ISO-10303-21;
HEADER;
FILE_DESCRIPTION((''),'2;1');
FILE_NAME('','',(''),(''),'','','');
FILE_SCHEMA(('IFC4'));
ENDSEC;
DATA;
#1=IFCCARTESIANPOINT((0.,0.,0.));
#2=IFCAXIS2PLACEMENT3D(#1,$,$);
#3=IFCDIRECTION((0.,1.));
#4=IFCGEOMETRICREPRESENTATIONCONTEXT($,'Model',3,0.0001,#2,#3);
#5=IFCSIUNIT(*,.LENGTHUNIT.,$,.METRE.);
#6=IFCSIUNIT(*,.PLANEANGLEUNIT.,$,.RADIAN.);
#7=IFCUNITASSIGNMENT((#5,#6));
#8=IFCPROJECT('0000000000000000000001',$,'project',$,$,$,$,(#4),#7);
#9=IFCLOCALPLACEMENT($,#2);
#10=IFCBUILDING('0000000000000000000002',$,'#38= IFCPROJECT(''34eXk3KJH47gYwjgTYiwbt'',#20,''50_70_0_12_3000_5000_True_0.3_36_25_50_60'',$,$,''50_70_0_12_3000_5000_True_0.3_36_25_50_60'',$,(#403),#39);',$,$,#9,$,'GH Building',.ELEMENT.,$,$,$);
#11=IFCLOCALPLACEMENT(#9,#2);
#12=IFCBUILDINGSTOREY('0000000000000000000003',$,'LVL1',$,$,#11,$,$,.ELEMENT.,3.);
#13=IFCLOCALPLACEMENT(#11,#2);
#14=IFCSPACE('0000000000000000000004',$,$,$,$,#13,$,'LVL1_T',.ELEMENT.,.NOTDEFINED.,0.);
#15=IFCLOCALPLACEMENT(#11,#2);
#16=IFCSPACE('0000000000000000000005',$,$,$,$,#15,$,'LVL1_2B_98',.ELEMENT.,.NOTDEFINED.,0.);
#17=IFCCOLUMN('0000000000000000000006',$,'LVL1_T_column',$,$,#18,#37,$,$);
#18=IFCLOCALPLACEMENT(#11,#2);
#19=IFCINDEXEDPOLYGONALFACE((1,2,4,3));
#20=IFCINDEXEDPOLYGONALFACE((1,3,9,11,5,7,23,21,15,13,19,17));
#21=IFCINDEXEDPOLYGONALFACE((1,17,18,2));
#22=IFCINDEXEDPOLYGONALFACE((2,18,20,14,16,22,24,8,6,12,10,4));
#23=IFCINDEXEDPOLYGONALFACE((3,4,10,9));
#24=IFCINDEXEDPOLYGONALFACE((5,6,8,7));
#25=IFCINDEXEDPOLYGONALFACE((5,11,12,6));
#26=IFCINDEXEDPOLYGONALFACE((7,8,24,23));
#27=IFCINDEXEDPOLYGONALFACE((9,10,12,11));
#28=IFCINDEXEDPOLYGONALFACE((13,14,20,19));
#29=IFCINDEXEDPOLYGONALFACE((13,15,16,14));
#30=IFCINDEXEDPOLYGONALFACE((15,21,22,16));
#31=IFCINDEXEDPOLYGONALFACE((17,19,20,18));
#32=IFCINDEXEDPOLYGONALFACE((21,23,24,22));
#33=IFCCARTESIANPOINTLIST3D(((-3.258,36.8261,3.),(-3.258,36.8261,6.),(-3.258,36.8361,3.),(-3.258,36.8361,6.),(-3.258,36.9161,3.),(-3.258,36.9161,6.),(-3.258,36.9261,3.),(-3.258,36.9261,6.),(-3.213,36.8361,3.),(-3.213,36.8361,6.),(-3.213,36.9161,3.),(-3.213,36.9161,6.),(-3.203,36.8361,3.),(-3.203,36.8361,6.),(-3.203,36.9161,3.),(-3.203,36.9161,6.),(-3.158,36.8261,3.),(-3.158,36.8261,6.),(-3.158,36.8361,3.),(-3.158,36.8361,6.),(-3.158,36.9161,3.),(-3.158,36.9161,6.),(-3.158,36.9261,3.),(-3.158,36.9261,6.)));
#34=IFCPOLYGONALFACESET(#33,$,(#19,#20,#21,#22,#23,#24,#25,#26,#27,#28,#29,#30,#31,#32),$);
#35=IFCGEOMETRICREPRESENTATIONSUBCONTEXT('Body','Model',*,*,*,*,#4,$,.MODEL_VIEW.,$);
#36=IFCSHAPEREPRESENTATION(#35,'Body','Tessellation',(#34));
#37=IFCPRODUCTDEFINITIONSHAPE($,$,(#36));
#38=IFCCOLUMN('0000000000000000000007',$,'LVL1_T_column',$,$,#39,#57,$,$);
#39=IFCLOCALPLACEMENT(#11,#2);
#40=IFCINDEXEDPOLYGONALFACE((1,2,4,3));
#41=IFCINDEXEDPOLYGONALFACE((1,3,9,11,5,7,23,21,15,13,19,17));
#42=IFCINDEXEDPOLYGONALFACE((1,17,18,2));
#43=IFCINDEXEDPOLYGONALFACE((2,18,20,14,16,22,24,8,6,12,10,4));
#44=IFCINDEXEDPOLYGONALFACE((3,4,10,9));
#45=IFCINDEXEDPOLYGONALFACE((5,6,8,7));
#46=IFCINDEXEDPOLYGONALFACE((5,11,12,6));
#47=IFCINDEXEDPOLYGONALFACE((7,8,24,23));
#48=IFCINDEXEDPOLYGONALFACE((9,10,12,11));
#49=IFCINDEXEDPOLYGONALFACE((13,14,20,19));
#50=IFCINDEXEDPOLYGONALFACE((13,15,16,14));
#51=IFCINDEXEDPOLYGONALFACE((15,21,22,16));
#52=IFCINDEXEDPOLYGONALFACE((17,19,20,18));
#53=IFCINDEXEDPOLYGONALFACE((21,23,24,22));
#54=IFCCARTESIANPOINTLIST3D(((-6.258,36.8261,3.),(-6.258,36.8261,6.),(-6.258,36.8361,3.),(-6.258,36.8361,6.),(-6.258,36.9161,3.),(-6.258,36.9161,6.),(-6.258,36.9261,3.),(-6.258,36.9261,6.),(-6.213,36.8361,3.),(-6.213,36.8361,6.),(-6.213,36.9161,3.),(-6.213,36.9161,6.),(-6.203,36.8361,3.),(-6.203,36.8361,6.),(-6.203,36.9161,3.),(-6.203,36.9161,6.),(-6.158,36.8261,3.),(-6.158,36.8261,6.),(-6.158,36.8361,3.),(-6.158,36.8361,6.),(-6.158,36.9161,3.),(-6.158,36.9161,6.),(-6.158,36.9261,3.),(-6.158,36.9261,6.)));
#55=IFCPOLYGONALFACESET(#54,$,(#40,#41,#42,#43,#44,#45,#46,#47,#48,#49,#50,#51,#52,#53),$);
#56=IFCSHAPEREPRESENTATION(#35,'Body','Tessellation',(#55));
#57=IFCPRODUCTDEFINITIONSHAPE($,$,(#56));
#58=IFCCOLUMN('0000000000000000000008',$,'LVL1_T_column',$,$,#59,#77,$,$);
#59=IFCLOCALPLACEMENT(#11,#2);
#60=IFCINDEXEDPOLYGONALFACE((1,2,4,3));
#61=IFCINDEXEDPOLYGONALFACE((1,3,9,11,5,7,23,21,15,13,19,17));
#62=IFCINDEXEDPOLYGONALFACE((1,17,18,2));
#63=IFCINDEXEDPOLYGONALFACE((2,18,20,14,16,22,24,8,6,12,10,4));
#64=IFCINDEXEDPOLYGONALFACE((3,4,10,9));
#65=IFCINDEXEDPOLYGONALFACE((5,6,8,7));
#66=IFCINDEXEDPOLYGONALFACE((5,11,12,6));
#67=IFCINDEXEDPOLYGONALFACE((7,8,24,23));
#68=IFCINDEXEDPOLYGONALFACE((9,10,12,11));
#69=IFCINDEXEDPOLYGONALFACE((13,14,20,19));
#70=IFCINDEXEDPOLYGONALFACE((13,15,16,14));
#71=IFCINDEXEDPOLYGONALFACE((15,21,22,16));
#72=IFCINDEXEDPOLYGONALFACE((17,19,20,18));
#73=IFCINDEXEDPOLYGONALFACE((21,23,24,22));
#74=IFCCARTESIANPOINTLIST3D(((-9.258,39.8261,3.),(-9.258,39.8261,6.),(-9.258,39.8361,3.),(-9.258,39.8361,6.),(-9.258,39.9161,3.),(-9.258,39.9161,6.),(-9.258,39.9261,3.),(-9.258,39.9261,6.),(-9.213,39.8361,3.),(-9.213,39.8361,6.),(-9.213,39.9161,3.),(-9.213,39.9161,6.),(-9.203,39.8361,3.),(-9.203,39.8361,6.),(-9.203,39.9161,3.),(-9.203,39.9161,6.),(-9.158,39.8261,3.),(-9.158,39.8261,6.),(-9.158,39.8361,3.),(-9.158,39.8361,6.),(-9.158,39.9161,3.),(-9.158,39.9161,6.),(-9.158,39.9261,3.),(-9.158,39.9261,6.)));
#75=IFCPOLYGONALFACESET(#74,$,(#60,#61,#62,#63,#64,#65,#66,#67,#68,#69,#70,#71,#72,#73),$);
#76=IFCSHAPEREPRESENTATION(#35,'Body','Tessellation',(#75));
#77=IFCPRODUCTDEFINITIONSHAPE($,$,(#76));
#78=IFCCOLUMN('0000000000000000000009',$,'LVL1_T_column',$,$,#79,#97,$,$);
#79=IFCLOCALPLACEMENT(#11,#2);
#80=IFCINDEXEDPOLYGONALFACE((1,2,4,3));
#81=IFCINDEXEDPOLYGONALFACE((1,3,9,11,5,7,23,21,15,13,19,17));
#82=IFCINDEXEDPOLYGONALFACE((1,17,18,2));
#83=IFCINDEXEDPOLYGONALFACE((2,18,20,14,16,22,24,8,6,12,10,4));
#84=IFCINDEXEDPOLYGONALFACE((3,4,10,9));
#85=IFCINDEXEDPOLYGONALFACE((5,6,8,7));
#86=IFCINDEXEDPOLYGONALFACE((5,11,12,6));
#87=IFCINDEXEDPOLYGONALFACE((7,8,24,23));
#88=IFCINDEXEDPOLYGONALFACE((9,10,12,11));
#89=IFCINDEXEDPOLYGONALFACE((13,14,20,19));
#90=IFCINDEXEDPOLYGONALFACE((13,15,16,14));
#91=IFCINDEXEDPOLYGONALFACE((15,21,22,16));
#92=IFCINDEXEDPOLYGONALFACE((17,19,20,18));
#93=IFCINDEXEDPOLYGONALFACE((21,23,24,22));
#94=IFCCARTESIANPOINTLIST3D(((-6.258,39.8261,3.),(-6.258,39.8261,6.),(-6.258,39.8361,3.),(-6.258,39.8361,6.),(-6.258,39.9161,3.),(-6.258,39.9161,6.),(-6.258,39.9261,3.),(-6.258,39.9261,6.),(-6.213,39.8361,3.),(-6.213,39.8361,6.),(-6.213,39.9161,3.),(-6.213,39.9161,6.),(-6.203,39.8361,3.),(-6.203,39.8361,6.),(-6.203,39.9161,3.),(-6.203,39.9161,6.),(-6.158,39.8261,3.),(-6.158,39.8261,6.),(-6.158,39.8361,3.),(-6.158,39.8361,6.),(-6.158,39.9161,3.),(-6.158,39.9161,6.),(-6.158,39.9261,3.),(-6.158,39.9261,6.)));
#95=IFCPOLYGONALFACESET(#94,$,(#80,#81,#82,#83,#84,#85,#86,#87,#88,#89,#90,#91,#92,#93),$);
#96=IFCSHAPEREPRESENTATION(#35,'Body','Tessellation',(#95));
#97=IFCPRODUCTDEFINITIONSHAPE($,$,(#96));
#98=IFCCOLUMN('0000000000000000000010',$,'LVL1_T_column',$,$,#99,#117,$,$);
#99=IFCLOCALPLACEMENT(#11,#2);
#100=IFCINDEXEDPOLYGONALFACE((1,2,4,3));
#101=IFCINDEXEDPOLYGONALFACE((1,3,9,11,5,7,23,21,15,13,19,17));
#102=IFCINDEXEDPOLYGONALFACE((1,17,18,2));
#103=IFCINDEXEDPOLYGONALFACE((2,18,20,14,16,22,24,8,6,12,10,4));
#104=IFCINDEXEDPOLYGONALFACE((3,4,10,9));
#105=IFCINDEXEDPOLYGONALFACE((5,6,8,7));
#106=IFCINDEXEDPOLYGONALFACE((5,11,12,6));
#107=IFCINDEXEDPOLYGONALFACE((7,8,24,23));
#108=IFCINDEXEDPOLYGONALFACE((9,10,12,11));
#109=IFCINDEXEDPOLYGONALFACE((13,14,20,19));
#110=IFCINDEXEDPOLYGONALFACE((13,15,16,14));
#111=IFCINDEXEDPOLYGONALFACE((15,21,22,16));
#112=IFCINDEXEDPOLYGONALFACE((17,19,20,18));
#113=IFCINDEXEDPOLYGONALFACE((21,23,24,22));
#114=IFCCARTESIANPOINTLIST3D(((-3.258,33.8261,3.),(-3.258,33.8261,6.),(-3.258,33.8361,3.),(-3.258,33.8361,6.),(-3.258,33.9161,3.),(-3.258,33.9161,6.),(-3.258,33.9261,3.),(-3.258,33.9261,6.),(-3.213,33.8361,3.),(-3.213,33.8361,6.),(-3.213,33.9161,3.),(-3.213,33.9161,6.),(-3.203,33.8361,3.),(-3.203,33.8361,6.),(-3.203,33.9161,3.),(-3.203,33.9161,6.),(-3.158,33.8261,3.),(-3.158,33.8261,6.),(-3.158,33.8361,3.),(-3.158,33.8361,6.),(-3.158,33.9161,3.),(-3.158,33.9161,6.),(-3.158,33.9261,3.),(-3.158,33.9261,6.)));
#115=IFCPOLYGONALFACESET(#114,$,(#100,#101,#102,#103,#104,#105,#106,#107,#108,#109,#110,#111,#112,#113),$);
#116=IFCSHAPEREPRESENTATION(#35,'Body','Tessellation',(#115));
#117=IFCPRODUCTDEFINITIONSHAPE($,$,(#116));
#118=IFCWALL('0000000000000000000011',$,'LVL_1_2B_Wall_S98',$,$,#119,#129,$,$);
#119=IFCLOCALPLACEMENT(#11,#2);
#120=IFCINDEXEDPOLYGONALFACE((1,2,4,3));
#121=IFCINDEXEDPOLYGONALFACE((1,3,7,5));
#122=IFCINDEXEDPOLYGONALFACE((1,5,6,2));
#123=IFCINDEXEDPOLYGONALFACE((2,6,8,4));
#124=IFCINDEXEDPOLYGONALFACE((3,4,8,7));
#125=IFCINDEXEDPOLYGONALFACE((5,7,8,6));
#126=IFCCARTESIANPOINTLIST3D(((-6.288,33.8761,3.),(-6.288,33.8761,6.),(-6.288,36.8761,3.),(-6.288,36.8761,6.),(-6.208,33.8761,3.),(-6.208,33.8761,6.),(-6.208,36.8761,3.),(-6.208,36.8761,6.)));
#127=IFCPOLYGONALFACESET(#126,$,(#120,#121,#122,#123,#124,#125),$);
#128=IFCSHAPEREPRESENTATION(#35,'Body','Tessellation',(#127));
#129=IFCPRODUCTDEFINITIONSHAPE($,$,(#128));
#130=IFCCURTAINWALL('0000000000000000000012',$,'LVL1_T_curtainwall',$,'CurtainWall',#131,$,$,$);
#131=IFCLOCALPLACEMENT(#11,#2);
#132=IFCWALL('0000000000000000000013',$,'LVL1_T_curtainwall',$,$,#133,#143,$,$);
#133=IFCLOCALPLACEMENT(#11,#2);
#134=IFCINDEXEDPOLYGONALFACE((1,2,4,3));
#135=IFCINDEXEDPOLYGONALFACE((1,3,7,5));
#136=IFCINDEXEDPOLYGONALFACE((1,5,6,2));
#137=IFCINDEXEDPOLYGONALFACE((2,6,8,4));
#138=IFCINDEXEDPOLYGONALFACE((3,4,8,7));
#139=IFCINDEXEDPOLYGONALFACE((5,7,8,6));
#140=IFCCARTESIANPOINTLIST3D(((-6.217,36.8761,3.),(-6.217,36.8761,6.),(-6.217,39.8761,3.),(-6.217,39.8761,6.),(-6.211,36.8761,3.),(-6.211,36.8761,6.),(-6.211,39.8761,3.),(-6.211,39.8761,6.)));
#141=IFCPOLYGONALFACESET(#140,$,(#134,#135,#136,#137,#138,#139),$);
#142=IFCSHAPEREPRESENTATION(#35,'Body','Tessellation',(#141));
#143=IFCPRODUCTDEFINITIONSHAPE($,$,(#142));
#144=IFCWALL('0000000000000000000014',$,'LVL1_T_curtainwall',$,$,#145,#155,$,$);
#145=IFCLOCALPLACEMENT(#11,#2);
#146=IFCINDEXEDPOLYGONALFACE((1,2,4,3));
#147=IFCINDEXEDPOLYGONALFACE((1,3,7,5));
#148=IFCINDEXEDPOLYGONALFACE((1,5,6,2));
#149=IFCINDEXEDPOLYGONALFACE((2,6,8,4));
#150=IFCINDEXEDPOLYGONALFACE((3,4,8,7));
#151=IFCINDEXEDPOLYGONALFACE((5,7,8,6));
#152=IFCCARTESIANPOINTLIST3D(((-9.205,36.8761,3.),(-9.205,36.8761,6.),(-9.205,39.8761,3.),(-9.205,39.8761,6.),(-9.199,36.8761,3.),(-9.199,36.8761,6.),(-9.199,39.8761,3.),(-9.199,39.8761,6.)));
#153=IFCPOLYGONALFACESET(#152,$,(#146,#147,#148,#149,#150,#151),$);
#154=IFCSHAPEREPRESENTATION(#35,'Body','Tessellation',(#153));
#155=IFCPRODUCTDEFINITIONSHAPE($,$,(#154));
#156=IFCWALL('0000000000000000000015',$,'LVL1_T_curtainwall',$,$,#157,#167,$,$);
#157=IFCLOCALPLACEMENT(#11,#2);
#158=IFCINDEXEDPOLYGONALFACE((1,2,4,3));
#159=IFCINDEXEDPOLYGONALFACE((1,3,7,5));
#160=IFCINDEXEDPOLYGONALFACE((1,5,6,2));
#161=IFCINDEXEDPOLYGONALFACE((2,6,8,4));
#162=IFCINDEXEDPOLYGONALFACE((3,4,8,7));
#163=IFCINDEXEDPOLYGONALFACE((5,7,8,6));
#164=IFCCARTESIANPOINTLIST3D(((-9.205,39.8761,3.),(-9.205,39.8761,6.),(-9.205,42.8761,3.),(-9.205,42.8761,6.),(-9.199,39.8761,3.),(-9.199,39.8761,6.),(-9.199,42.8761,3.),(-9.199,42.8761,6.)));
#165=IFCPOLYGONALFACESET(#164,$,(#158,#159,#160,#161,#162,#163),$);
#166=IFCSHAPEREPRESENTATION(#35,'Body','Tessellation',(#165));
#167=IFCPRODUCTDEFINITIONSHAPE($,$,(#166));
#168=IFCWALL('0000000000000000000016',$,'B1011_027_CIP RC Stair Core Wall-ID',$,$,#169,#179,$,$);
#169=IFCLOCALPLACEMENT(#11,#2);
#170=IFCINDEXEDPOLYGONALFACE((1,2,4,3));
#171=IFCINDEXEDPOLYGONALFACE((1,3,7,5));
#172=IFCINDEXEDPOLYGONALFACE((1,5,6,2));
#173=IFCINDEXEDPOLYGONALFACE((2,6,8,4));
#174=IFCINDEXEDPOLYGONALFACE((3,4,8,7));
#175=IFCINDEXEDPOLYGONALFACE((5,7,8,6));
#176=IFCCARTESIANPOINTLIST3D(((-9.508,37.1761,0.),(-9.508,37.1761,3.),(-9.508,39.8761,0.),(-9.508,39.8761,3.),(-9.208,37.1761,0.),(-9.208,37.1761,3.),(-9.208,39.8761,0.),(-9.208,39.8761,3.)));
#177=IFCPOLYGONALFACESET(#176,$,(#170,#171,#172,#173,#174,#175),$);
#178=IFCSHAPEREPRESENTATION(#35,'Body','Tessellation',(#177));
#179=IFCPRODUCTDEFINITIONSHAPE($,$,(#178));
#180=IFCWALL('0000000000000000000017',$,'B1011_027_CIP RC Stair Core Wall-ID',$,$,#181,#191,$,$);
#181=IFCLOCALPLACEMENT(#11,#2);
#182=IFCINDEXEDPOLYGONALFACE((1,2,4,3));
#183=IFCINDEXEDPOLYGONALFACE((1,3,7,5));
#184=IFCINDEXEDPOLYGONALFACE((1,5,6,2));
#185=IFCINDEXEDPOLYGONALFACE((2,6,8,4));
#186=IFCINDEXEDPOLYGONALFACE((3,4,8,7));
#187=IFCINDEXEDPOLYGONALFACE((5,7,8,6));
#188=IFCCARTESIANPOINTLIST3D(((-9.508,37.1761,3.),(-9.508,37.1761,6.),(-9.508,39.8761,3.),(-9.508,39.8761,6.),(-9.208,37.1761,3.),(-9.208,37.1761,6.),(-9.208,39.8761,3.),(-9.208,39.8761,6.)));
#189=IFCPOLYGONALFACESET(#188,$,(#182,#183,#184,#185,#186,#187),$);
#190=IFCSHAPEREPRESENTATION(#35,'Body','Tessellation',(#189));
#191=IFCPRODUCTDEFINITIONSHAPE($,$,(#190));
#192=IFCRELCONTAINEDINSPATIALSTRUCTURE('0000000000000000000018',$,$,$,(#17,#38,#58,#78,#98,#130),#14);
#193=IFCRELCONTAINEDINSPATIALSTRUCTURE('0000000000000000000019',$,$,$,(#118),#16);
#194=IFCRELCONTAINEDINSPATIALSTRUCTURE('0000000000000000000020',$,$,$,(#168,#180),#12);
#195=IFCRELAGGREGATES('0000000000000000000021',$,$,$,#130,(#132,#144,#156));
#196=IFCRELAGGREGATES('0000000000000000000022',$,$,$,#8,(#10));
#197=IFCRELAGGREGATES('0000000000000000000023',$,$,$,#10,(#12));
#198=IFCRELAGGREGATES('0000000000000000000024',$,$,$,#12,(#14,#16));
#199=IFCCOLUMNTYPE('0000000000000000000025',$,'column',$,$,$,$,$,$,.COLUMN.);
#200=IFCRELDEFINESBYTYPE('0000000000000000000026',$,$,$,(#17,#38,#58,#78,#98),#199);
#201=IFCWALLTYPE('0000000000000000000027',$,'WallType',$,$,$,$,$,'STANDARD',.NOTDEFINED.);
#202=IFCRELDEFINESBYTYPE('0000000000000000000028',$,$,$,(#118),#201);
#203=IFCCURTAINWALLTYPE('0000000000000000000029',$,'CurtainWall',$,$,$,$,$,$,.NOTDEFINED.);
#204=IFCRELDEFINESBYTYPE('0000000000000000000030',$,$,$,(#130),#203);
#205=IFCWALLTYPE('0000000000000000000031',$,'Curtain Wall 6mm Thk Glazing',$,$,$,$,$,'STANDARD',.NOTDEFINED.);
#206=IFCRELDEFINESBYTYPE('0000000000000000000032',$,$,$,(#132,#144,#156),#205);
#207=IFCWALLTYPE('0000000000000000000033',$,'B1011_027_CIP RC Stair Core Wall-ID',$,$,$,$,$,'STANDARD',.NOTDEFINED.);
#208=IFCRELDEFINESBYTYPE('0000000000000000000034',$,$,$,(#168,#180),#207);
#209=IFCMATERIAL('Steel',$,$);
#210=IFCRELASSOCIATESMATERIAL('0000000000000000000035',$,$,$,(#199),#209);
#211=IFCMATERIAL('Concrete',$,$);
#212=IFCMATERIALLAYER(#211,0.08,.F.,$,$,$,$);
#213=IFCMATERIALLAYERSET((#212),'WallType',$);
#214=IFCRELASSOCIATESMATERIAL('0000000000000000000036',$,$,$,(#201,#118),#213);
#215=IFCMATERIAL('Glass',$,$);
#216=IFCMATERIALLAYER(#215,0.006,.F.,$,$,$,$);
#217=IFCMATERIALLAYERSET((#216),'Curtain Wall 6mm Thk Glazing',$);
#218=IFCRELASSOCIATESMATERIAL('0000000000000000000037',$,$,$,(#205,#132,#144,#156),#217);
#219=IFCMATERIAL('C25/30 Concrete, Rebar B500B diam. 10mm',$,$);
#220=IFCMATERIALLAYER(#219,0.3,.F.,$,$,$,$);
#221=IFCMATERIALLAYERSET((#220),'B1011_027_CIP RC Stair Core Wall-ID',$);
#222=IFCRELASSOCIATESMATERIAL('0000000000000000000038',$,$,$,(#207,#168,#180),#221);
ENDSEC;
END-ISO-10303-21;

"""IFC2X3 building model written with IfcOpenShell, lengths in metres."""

from ifc_helpers import new_model, si_unit, direction, frame, frame_2d, origin, origin_2d, place, context, subcontext, project, spatial, rectangle, i_section, extrude, material, layer, layer_set, layer_usage, type_object, element, aggregate, save


model = new_model("IFC2X3")

# Units and contexts
model_context = context("Model", 3, precision=0.0001, world=origin(), true_north=direction((0.0, 1.0)))
body_context = subcontext(model_context, "Body", "Model", "MODEL_VIEW")
ifc_project = project(units=[si_unit("LENGTHUNIT", "METRE"), si_unit("PLANEANGLEUNIT", "RADIAN")], contexts=[model_context])

# Building, storey, space
building_placement = place(None, origin())
building = spatial("IfcBuilding", under=ifc_project, at=building_placement, Name="#38= IFCPROJECT('34eXk3KJH47gYwjgTYiwbt',#20,'50_70_0_12_3000_5000_True_0.3_36_25_50_60',$,$,'50_70_0_12_3000_5000_True_0.3_36_25_50_60',$,(#403),#39);", LongName="GH Building", CompositionType="ELEMENT")
storey_placement = place(building_placement, origin())
storey = spatial("IfcBuildingStorey", under=building, at=storey_placement, Name="LVL1", CompositionType="ELEMENT", Elevation=3.0)
space_1_placement = place(storey_placement, origin())
space_1 = spatial("IfcSpace", under=storey, at=space_1_placement, LongName="LVL1_T", CompositionType="ELEMENT", InteriorOrExteriorSpace="NOTDEFINED", ElevationWithFlooring=0.0)

# Columns
ifc_material_1 = material(Name="Steel")
column_type = type_object("IfcColumnType", Name="column", PredefinedType="COLUMN", material=ifc_material_1)
for number, where, name in (
    (1, (-3.208, 36.8761, 3.0), "LVL1_T_column"),
    (2, (-6.208, 36.8761, 3.0), "LVL1_T_column"),
    (3, (-9.208, 39.8761, 3.0), "LVL1_T_column"),
    (4, (-6.208, 39.8761, 3.0), "LVL1_T_column"),
    (5, (-3.208, 33.8761, 3.0), "LVL1_T_column"),
):
    element("IfcColumn", number, at=place(space_1_placement, frame(where)), inside=space_1, type_object=column_type, Name=name, context=body_context, shape_type="SweptSolid", body=[
        extrude(i_section(OverallWidth=0.1, OverallDepth=0.1, WebThickness=0.01, FlangeThickness=0.01, at=origin_2d()), origin(), (0.0, 0.0, 1.0), 3.0),
    ])

# Shared definitions
space_2_placement = place(storey_placement, origin())
space_2 = spatial("IfcSpace", under=storey, at=space_2_placement, LongName="LVL1_2B_98", CompositionType="ELEMENT", InteriorOrExteriorSpace="NOTDEFINED", ElevationWithFlooring=0.0)

# Shared definitions
ifc_material_2 = material(Name="Concrete")
ifc_layer_1 = layer(ifc_material_2, 0.08, ventilated=False)
ifc_layer_set_1 = layer_set([ifc_layer_1], Name="WallType")
wall_type_1 = type_object("IfcWallType", Name="WallType", ElementType="STANDARD", PredefinedType="NOTDEFINED", material=ifc_layer_set_1)

# Wall
ifc_layer_usage_1 = layer_usage(ifc_layer_set_1, "AXIS2", "NEGATIVE", 0.0)
wall_1_placement = place(space_2_placement, frame((-6.208, 36.8761, 3.0), z_axis=(0.0, 0.0, 1.0), x_axis=(0.0, -1.0, 0.0)))
element("IfcWall", 6, at=wall_1_placement, inside=space_2, type_object=wall_type_1, material=ifc_layer_usage_1, Name="LVL_1_2B_Wall_S98", context=body_context, shape_type="SweptSolid", body=[
    extrude(rectangle(XDim=3.0, YDim=0.08, at=frame_2d((1.5, -0.04))), origin(), (0.0, 0.0, 1.0), 3.0),
])

# Curtain wall, walls
curtain_wall_type = type_object("IfcCurtainWallType", Name="CurtainWall", PredefinedType="NOTDEFINED")
curtain_wall_placement = place(None, origin())
curtain_wall = element("IfcCurtainWall", 7, at=curtain_wall_placement, inside=space_1, type_object=curtain_wall_type, Name="LVL1_T_curtainwall", ObjectType="CurtainWall")
ifc_material_3 = material(Name="Glass")
ifc_layer_2 = layer(ifc_material_3, 0.006, ventilated=False)
ifc_layer_set_2 = layer_set([ifc_layer_2], Name="Curtain Wall 6mm Thk Glazing")
ifc_layer_usage_2 = layer_usage(ifc_layer_set_2, "AXIS2", "NEGATIVE", -0.003)
wall_type_2 = type_object("IfcWallType", Name="Curtain Wall 6mm Thk Glazing", ElementType="STANDARD", PredefinedType="NOTDEFINED", material=ifc_layer_set_2)
wall_2_placement = place(curtain_wall_placement, frame((-6.208, 39.8761, 3.0), z_axis=(0.0, 0.0, 1.0), x_axis=(0.0, -1.0, 0.0)))
wall_2 = element("IfcWall", 8, at=wall_2_placement, type_object=wall_type_2, material=ifc_layer_usage_2, Name="LVL1_T_curtainwall", context=body_context, shape_type="SweptSolid", body=[
    extrude(rectangle(XDim=3.0, YDim=0.006, at=frame_2d((1.5, -0.006))), origin(), (0.0, 0.0, 1.0), 3.0),
])
ifc_layer_usage_3 = layer_usage(ifc_layer_set_2, "AXIS2", "NEGATIVE", -0.003)
wall_3_placement = place(curtain_wall_placement, frame((-9.208, 36.8761, 3.0), z_axis=(0.0, 0.0, 1.0), x_axis=(0.0, 1.0, 0.0)))
wall_3 = element("IfcWall", 9, at=wall_3_placement, type_object=wall_type_2, material=ifc_layer_usage_3, Name="LVL1_T_curtainwall", context=body_context, shape_type="SweptSolid", body=[
    extrude(rectangle(XDim=3.0, YDim=0.006, at=frame_2d((1.5, -0.006))), origin(), (0.0, 0.0, 1.0), 3.0),
])
ifc_layer_usage_4 = layer_usage(ifc_layer_set_2, "AXIS2", "NEGATIVE", -0.003)
wall_4_placement = place(curtain_wall_placement, frame((-9.208, 39.8761, 3.0), z_axis=(0.0, 0.0, 1.0), x_axis=(0.0, 1.0, 0.0)))
wall_4 = element("IfcWall", 10, at=wall_4_placement, type_object=wall_type_2, material=ifc_layer_usage_4, Name="LVL1_T_curtainwall", context=body_context, shape_type="SweptSolid", body=[
    extrude(rectangle(XDim=3.0, YDim=0.006, at=frame_2d((1.5, -0.006))), origin(), (0.0, 0.0, 1.0), 3.0),
])
aggregate(curtain_wall, [wall_2, wall_3, wall_4])

# Walls
ifc_material_4 = material(Name="C25/30 Concrete, Rebar B500B diam. 10mm")
ifc_layer_3 = layer(ifc_material_4, 0.3, ventilated=False)
ifc_layer_set_3 = layer_set([ifc_layer_3], Name="B1011_027_CIP RC Stair Core Wall-ID")
ifc_layer_usage_5 = layer_usage(ifc_layer_set_3, "AXIS2", "POSITIVE", 0.0)
wall_type_3 = type_object("IfcWallType", Name="B1011_027_CIP RC Stair Core Wall-ID", ElementType="STANDARD", PredefinedType="NOTDEFINED", material=ifc_layer_set_3)
wall_5_placement = place(storey_placement, frame((-9.208, 37.1761, 0.0), z_axis=(0.0, 0.0, 1.0), x_axis=(0.0, 1.0, 0.0)))
element("IfcWall", 11, at=wall_5_placement, inside=storey, type_object=wall_type_3, material=ifc_layer_usage_5, Name="B1011_027_CIP RC Stair Core Wall-ID", context=body_context, shape_type="SweptSolid", body=[
    extrude(rectangle(XDim=2.7, YDim=0.3, at=frame_2d((1.35, 0.15))), origin(), (0.0, 0.0, 1.0), 3.0),
])
ifc_layer_usage_6 = layer_usage(ifc_layer_set_3, "AXIS2", "POSITIVE", 0.0)
wall_6_placement = place(storey_placement, frame((-9.208, 37.1761, 3.0), z_axis=(0.0, 0.0, 1.0), x_axis=(0.0, 1.0, 0.0)))
element("IfcWall", 12, at=wall_6_placement, inside=storey, type_object=wall_type_3, material=ifc_layer_usage_6, Name="B1011_027_CIP RC Stair Core Wall-ID", context=body_context, shape_type="SweptSolid", body=[
    extrude(rectangle(XDim=2.7, YDim=0.3, at=frame_2d((1.35, 0.15))), origin(), (0.0, 0.0, 1.0), 3.0),
])

save(model, "model.ifc")
